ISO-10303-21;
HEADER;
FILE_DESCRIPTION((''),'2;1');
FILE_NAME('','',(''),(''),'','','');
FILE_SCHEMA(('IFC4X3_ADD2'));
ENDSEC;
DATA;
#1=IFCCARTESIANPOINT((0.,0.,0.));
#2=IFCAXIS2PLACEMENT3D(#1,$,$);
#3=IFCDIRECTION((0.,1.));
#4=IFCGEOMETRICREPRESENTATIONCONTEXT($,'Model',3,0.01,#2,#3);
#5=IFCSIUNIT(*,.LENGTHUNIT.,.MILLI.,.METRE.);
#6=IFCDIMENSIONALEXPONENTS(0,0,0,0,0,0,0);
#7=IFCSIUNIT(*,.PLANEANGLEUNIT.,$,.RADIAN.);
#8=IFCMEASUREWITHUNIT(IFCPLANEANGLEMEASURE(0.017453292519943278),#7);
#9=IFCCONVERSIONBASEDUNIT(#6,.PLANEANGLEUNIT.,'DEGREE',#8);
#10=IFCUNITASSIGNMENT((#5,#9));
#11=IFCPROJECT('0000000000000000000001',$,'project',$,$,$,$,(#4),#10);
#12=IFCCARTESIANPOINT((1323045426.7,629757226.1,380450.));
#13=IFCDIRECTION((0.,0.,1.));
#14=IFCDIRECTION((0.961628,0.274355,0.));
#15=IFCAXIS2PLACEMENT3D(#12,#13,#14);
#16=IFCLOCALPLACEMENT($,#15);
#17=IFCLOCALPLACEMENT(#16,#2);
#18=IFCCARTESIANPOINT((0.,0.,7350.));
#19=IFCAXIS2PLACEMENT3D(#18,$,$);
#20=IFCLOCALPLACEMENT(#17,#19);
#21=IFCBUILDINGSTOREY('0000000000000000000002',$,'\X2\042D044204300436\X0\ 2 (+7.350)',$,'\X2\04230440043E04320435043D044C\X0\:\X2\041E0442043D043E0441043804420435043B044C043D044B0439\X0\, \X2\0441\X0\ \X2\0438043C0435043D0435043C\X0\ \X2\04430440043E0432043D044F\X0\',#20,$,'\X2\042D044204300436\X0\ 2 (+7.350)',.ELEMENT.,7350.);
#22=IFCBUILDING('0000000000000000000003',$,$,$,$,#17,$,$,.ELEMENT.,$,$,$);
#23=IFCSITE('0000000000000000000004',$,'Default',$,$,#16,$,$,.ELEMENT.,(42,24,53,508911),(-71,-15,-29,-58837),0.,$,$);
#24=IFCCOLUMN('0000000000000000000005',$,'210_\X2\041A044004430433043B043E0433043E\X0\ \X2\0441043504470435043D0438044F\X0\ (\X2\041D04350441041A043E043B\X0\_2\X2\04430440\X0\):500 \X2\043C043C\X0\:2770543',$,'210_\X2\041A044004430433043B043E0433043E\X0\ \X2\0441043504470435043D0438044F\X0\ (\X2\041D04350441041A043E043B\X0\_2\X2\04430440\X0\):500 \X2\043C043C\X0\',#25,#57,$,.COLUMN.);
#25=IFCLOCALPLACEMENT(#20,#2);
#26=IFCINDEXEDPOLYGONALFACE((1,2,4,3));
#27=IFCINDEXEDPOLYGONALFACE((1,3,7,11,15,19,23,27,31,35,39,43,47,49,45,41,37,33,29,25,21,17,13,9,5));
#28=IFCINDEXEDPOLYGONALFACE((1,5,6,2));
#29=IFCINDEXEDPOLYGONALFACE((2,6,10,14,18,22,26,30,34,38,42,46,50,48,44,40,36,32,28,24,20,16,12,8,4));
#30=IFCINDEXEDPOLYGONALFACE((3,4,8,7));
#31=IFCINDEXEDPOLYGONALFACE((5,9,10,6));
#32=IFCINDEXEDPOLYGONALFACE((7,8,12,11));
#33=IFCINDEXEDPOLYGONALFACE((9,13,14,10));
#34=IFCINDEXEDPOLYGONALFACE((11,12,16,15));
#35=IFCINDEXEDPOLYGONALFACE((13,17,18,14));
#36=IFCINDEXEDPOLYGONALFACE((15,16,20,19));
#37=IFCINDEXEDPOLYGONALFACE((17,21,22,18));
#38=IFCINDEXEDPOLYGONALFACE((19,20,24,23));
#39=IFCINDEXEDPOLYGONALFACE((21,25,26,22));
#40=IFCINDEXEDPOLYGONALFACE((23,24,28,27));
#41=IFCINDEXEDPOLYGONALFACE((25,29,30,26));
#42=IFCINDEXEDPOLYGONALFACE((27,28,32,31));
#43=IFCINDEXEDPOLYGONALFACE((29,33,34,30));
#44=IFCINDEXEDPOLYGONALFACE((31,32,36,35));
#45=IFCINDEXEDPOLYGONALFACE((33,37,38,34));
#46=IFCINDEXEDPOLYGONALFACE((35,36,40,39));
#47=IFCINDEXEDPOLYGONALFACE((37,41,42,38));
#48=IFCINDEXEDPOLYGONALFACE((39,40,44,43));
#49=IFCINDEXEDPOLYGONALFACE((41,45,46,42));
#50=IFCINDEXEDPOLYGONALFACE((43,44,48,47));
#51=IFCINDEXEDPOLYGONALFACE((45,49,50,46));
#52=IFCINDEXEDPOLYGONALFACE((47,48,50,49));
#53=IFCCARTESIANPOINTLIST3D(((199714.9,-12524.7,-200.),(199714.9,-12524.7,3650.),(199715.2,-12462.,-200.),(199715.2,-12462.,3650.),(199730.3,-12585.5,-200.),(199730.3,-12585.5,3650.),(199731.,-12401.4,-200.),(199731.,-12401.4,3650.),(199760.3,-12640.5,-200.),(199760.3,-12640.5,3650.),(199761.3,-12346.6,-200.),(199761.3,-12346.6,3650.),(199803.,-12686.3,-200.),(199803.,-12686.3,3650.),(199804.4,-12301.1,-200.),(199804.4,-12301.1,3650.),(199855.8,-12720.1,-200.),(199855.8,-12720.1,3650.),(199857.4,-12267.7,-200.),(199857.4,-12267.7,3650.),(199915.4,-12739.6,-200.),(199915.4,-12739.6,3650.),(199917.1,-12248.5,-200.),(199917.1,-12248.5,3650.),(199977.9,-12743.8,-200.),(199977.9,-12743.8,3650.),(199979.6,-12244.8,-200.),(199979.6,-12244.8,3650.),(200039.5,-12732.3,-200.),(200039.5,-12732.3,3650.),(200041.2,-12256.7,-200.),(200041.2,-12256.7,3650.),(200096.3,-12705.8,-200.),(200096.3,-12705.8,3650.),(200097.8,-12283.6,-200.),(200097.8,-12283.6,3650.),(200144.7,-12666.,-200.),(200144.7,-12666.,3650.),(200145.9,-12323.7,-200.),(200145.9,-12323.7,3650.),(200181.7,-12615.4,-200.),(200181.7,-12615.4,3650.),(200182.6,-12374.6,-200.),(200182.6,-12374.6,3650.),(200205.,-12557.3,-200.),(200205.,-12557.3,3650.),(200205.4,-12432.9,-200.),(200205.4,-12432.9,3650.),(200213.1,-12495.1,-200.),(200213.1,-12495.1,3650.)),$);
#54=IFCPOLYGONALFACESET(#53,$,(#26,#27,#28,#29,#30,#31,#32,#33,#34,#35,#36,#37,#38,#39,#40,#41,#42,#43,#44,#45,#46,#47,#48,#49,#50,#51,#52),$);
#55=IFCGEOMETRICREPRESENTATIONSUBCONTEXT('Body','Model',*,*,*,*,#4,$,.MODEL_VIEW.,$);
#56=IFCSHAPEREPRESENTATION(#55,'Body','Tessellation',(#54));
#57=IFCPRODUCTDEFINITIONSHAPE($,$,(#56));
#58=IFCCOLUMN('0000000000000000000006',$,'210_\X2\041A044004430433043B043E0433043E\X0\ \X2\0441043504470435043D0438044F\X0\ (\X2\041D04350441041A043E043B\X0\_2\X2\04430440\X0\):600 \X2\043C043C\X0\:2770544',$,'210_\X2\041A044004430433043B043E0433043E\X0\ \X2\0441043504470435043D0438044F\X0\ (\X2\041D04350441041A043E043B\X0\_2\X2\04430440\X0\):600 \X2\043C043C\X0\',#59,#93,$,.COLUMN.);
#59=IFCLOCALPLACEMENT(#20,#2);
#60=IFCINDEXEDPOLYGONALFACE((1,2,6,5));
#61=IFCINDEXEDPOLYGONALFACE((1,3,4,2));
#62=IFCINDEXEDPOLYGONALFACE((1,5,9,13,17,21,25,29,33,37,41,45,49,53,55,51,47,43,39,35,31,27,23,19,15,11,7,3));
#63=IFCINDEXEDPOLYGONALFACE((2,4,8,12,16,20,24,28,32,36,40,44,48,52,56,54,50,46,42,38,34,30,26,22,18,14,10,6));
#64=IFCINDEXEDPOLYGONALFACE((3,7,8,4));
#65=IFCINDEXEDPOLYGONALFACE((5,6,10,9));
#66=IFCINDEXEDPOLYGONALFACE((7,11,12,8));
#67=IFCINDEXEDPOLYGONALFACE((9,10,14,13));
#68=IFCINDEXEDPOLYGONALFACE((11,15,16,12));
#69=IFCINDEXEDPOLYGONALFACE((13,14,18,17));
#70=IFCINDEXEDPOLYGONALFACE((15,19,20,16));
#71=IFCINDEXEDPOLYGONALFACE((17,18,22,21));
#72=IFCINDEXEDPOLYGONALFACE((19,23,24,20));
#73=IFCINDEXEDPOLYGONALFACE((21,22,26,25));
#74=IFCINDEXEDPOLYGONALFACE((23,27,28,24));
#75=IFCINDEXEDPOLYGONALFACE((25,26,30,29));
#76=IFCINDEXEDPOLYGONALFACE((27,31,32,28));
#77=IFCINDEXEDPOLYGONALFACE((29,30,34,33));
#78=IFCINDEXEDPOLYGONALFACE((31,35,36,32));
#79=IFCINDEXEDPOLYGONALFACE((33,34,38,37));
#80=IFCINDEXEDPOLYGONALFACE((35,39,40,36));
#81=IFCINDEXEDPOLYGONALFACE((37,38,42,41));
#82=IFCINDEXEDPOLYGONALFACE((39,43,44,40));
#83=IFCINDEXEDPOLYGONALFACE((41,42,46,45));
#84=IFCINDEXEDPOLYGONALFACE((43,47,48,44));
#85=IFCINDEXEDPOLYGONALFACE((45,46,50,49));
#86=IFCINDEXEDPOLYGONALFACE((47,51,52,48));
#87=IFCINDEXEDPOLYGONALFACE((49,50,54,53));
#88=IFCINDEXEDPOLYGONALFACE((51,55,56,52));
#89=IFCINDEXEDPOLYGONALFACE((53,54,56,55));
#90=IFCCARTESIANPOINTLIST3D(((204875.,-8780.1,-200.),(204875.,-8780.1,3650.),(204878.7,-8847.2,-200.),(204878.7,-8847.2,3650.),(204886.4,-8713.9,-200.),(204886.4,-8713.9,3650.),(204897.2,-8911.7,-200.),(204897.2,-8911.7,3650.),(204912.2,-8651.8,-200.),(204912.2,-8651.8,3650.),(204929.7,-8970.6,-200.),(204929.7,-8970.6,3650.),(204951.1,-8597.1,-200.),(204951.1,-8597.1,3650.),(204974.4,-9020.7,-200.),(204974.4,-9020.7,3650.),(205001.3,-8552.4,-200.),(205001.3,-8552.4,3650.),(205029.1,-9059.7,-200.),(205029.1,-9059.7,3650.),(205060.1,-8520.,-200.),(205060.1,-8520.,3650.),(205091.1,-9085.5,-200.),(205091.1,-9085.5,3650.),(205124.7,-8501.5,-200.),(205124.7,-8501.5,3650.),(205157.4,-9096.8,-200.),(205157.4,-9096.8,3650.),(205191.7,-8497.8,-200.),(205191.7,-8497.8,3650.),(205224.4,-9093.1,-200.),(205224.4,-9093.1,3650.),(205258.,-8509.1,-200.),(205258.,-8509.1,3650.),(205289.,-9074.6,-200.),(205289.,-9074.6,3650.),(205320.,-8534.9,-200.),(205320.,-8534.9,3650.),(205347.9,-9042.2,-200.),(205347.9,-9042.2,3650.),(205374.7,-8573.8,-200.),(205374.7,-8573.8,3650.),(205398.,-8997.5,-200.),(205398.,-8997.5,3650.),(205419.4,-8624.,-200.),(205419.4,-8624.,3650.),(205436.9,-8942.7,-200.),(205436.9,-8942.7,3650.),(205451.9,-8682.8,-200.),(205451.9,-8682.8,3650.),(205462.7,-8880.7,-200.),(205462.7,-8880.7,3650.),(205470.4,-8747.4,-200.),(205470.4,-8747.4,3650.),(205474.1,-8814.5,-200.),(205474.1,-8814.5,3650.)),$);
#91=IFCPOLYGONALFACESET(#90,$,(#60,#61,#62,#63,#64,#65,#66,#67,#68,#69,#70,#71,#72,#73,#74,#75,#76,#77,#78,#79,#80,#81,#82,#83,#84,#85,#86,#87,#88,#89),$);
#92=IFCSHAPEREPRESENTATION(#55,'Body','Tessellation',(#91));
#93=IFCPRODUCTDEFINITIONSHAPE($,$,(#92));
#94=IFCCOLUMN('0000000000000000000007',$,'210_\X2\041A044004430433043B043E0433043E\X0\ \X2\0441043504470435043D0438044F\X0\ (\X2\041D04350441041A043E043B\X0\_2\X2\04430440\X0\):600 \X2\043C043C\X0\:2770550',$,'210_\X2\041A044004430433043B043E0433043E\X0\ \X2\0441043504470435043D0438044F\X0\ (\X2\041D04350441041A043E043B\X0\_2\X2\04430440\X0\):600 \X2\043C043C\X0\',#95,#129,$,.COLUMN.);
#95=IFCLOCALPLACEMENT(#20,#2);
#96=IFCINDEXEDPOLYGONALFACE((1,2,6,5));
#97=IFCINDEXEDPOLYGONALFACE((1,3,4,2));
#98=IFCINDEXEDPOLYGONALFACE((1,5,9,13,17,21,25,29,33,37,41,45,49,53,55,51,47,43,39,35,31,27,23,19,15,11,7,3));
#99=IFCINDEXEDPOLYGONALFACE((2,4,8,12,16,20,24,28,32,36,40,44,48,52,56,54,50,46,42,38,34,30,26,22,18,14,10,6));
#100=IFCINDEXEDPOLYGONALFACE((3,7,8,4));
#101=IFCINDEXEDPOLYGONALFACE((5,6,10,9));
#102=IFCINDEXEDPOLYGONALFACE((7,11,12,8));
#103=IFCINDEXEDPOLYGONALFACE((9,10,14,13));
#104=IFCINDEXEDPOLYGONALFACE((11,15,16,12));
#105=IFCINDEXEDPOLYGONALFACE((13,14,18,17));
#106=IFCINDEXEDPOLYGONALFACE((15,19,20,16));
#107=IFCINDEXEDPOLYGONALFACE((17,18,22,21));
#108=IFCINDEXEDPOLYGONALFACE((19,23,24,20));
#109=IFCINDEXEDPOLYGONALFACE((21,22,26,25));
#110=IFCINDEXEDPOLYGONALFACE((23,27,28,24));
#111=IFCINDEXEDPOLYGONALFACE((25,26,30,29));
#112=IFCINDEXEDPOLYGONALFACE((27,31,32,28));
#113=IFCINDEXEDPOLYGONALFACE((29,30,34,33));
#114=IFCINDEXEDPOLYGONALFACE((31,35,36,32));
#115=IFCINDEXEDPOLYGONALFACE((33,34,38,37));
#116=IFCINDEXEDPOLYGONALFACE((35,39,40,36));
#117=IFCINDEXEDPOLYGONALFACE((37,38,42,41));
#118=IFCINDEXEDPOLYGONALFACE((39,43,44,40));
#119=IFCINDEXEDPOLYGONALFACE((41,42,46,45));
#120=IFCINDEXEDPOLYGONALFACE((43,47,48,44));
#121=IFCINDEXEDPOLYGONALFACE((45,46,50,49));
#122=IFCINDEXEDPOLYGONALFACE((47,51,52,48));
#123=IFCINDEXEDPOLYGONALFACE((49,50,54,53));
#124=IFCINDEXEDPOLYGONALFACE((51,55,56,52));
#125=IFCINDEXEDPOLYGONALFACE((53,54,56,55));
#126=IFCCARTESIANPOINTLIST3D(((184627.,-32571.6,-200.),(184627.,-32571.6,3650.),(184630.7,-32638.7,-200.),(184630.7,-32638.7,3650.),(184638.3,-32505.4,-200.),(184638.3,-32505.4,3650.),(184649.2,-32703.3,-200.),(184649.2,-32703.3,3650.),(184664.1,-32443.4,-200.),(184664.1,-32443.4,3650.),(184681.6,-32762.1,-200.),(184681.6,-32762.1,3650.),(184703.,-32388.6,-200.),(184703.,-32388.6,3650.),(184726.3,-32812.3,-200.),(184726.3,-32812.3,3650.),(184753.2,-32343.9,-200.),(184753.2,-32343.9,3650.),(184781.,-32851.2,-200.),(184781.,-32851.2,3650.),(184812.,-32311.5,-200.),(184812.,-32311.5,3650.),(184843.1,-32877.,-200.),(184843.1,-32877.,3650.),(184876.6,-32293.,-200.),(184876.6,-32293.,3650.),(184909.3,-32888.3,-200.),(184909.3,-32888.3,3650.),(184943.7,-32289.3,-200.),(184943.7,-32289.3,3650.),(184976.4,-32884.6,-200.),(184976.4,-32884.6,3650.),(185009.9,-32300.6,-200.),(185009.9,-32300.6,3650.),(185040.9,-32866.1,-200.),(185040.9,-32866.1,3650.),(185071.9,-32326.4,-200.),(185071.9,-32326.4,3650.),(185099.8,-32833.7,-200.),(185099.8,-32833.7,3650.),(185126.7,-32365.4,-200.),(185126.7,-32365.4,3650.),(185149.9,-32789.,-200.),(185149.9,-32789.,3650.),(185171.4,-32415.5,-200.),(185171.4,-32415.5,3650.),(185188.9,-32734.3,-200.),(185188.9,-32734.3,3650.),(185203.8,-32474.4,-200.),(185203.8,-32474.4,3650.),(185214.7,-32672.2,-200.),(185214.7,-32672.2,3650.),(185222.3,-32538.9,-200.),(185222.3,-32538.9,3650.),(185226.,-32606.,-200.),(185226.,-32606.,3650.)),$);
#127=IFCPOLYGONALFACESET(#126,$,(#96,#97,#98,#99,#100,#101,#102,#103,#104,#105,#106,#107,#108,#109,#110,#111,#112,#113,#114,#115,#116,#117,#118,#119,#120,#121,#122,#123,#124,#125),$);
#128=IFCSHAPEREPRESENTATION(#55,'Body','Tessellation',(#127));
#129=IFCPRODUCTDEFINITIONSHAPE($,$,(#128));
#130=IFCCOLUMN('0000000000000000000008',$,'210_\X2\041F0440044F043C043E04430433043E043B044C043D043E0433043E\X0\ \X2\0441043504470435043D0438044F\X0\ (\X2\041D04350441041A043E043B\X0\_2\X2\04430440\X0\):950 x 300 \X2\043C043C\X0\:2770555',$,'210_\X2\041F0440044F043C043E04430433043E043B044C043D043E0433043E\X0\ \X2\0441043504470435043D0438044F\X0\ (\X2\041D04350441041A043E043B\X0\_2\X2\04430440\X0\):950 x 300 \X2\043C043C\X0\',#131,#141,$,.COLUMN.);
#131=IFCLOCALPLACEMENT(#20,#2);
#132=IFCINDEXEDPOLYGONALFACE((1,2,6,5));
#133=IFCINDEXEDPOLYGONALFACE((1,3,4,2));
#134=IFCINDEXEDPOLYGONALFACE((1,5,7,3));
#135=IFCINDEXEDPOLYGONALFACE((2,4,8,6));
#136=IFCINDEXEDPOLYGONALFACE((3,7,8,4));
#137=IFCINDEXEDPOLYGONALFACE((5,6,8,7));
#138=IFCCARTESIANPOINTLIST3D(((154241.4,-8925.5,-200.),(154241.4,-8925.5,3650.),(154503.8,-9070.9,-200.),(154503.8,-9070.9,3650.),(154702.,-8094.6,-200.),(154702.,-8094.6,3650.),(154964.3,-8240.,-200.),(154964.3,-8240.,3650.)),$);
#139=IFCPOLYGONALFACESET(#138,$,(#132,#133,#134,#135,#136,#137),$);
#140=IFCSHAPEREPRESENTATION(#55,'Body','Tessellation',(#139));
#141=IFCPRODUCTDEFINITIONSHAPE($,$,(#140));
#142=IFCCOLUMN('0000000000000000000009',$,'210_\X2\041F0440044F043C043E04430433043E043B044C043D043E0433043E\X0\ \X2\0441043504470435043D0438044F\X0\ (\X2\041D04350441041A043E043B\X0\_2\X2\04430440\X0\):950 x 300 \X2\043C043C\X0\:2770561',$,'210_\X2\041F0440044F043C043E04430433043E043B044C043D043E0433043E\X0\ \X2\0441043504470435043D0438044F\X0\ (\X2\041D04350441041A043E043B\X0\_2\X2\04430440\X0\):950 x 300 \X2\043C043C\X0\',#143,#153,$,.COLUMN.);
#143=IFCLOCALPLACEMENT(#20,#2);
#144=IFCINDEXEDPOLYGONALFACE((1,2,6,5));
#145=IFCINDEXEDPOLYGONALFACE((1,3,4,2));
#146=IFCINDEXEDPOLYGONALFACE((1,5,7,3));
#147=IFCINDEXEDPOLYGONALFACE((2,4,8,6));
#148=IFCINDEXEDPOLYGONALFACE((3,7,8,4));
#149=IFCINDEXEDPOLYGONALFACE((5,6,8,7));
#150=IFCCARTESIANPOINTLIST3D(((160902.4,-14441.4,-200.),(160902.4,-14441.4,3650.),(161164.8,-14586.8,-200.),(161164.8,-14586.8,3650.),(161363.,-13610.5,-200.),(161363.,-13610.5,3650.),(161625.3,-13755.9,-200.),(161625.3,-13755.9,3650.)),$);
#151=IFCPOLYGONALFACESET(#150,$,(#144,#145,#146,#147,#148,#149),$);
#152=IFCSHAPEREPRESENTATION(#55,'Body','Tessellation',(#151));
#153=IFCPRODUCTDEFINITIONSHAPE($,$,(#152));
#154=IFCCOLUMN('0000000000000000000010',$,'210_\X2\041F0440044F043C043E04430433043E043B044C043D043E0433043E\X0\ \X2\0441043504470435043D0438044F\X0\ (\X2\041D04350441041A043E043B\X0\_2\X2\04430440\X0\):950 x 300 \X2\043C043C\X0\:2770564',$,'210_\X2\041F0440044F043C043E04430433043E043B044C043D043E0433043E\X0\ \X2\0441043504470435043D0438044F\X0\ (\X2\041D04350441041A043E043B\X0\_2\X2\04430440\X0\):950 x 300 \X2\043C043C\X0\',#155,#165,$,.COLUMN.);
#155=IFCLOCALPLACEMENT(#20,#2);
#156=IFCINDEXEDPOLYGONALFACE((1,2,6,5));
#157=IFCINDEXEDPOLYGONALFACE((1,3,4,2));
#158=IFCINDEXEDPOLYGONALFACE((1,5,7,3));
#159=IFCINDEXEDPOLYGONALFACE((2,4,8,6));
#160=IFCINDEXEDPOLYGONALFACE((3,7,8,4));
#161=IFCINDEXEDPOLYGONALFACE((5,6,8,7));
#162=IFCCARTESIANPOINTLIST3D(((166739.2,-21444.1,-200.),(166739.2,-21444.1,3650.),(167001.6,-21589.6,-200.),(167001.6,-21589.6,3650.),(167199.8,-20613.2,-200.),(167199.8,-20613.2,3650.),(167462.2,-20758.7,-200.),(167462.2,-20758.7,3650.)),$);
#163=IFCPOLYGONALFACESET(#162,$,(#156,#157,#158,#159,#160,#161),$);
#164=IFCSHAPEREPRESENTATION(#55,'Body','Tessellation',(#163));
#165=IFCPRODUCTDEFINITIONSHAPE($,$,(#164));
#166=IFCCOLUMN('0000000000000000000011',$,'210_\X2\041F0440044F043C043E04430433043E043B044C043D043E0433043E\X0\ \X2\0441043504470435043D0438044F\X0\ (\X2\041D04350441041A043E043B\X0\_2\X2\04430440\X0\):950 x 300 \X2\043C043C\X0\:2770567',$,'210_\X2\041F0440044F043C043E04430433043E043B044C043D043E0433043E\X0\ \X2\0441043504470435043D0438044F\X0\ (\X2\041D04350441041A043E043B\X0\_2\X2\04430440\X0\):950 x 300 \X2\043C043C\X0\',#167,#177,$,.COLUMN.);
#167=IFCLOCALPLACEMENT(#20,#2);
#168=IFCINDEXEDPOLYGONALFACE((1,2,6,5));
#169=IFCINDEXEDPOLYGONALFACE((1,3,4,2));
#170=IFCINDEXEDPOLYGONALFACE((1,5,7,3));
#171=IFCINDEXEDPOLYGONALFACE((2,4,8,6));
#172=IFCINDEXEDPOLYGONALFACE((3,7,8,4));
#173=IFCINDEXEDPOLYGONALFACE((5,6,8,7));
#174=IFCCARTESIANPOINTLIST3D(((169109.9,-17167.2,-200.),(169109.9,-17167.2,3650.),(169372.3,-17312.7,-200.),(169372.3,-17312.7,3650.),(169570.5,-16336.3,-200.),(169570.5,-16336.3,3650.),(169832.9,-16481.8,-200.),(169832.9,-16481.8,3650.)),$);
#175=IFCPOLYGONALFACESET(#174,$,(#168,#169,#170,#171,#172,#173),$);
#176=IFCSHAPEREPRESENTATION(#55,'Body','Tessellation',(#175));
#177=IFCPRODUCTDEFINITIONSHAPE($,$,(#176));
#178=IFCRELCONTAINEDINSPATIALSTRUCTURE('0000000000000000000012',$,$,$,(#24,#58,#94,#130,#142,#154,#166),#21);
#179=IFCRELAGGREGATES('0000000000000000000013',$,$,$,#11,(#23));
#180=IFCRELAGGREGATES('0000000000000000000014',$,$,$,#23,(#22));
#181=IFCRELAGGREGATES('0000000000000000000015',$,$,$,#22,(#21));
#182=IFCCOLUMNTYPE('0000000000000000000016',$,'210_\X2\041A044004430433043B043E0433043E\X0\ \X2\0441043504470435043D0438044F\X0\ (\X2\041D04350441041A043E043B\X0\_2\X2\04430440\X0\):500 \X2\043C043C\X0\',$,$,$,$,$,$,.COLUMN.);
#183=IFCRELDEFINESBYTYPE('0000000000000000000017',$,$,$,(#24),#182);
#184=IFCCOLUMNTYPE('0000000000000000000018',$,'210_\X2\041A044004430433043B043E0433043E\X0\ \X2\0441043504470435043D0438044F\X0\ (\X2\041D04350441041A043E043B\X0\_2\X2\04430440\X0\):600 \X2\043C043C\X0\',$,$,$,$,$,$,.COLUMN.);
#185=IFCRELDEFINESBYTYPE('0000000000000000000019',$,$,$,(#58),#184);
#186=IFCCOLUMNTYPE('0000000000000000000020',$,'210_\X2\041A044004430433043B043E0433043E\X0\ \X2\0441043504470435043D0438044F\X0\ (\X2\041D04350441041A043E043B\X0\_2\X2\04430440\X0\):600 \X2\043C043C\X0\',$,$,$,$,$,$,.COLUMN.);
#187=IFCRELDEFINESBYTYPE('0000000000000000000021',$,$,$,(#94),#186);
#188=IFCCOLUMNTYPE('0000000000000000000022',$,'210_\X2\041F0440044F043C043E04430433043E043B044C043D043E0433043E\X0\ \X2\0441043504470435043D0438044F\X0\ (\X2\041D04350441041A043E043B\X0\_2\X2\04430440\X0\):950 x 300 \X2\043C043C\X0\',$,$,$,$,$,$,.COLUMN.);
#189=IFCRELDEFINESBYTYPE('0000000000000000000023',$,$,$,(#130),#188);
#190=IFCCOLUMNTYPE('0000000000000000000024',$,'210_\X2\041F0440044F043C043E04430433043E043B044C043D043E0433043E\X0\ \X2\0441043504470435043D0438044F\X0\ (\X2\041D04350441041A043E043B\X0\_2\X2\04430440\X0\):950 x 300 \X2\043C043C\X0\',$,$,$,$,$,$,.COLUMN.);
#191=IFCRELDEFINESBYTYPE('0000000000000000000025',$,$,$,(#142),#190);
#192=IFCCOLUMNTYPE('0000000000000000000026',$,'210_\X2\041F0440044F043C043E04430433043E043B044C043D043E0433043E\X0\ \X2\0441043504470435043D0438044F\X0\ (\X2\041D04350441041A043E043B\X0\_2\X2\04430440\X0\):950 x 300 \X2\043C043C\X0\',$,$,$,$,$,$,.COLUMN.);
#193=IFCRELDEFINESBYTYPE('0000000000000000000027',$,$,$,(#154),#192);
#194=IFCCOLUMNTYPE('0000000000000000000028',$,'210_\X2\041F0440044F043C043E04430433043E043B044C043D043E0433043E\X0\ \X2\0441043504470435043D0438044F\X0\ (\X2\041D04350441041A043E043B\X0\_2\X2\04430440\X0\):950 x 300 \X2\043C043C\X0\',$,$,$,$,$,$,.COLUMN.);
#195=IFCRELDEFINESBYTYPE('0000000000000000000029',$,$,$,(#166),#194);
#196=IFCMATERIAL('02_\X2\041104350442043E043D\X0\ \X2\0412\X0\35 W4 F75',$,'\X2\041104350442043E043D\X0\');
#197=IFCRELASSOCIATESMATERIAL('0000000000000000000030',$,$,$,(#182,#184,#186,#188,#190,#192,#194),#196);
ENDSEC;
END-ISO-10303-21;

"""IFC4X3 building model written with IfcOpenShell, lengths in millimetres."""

from ifc_helpers import new_model, entity, si_unit, converted_unit, direction, frame, frame_2d, origin, origin_2d_with_axis, place, context, subcontext, project, spatial, rectangle, circle, extrude, source, transform, mapped, material, material_profile, profile_set, type_object, type_shapes, element, save


model = new_model("IFC4X3")

# Units and contexts
model_context = context("Model", 3, precision=0.01, world=origin(), true_north=direction((0.0, 1.0)))
body_context = subcontext(model_context, "Body", "Model", "MODEL_VIEW")
ifc_project = project(units=[si_unit("LENGTHUNIT", "METRE", prefix="MILLI"), converted_unit("PLANEANGLEUNIT", "DEGREE", entity("IfcPlaneAngleMeasure", 0.017453292519943278), si_unit("PLANEANGLEUNIT", "RADIAN"), dimensions=[0, 0, 0, 0, 0, 0, 0])], contexts=[model_context])

# Site, building, storey
site_placement = place(None, frame((1323045426.7, 629757226.1, 380450.0), z_axis=(0.0, 0.0, 1.0), x_axis=(0.961628, 0.274355, 0.0)))
site = spatial("IfcSite", under=ifc_project, at=site_placement, Name="Default", CompositionType="ELEMENT", RefLatitude=(42, 24, 53, 508911), RefLongitude=(-71, -15, -29, -58837), RefElevation=0.0)
building_placement = place(site_placement, origin())
building = spatial("IfcBuilding", under=site, at=building_placement, CompositionType="ELEMENT")
storey_placement = place(building_placement, frame((0.0, 0.0, 7350.0)))
storey = spatial("IfcBuildingStorey", under=building, at=storey_placement, Name="Этаж 2 (+7.350)", ObjectType="Уровень:Относительный, с именем уровня", LongName="Этаж 2 (+7.350)", CompositionType="ELEMENT", Elevation=7350.0)

# Columns
ifc_material = material(Name="02_Бетон В35 W4 F75", Category="Бетон")
ifc_material_profile_1 = material_profile(ifc_material, circle(Radius=250.0, at=frame_2d((0.0, 0.0), x_axis=(1.0, 0.0))), Name="500 мм")
ifc_profile_set_1 = profile_set([ifc_material_profile_1], Name="500 мм")
ifc_material_profile_2 = material_profile(ifc_material, circle(Radius=300.0, at=origin_2d_with_axis()), Name="600 мм")
ifc_profile_set_2 = profile_set([ifc_material_profile_2], Name="600 мм")
column_type_1 = type_object("IfcColumnType", Name="210_Круглого сечения (НесКол_2ур):500 мм", PredefinedType="COLUMN", material=ifc_profile_set_1)
shared_shape_1 = source(origin(), body_context, "Body", "SweptSolid", [
    extrude(circle(Radius=250.0, at=origin_2d_with_axis()), frame((199963.1, -12494.2, 7150.0), z_axis=(0.0, 0.0, 1.0), x_axis=(0.87462, -0.48481, 0.0)), (0.0, 0.0, 1.0), 3850.0),
])
type_shapes(column_type_1, [shared_shape_1])
column_1_placement = place(storey_placement, frame((0.0, 0.0, -7350.0)))
element("IfcColumn", 1, at=column_1_placement, inside=storey, type_object=column_type_1, Name="210_Круглого сечения (НесКол_2ур):500 мм:2770543", ObjectType="210_Круглого сечения (НесКол_2ур):500 мм", PredefinedType="COLUMN", context=body_context, shape_type="MappedRepresentation", body=[
    mapped(shared_shape_1, transform((0.0, 0.0, 0.0), scale=1.0)),
])
column_type_2 = type_object("IfcColumnType", Name="210_Круглого сечения (НесКол_2ур):600 мм", PredefinedType="COLUMN", material=ifc_profile_set_2)
shared_shape_2 = source(origin(), body_context, "Body", "SweptSolid", [
    extrude(circle(Radius=300.0, at=origin_2d_with_axis()), frame((205174.6, -8797.3, 7150.0), z_axis=(0.0, 0.0, 1.0), x_axis=(0.87462, -0.48481, 0.0)), (0.0, 0.0, 1.0), 3850.0),
])
type_shapes(column_type_2, [shared_shape_2])
column_2_placement = place(storey_placement, frame((0.0, 0.0, -7350.0)))
element("IfcColumn", 2, at=column_2_placement, inside=storey, type_object=column_type_2, Name="210_Круглого сечения (НесКол_2ур):600 мм:2770544", ObjectType="210_Круглого сечения (НесКол_2ур):600 мм", PredefinedType="COLUMN", context=body_context, shape_type="MappedRepresentation", body=[
    mapped(shared_shape_2, transform((0.0, 0.0, 0.0), scale=1.0)),
])
column_type_3 = type_object("IfcColumnType", Name="210_Круглого сечения (НесКол_2ур):600 мм", PredefinedType="COLUMN", material=ifc_profile_set_2)
shared_shape_3 = source(origin(), body_context, "Body", "SweptSolid", [
    extrude(circle(Radius=300.0, at=origin_2d_with_axis()), frame((184926.5, -32588.8, 7150.0), z_axis=(0.0, 0.0, 1.0), x_axis=(0.87462, -0.48481, 0.0)), (0.0, 0.0, 1.0), 3850.0),
])
type_shapes(column_type_3, [shared_shape_3])
column_3_placement = place(storey_placement, frame((0.0, 0.0, -7350.0)))
element("IfcColumn", 3, at=column_3_placement, inside=storey, type_object=column_type_3, Name="210_Круглого сечения (НесКол_2ур):600 мм:2770550", ObjectType="210_Круглого сечения (НесКол_2ур):600 мм", PredefinedType="COLUMN", context=body_context, shape_type="MappedRepresentation", body=[
    mapped(shared_shape_3, transform((0.0, 0.0, 0.0), scale=1.0)),
])
ifc_material_profile_3 = material_profile(ifc_material, rectangle(XDim=300.0, YDim=950.0, at=origin_2d_with_axis()), Name="950 x 300 мм")
ifc_profile_set_3 = profile_set([ifc_material_profile_3], Name="950 x 300 мм")
column_type_4 = type_object("IfcColumnType", Name="210_Прямоугольного сечения (НесКол_2ур):950 x 300 мм", PredefinedType="COLUMN", material=ifc_profile_set_3)
shared_shape_4 = source(origin(), body_context, "Body", "SweptSolid", [
    extrude(rectangle(XDim=300.0, YDim=950.0, at=origin_2d_with_axis()), frame((154602.9, -8582.8, 7150.0), z_axis=(0.0, 0.0, 1.0), x_axis=(-0.87462, 0.48481, 0.0)), (0.0, 0.0, 1.0), 3850.0),
])
type_shapes(column_type_4, [shared_shape_4])
column_4_placement = place(storey_placement, frame((0.0, 0.0, -7350.0)))
element("IfcColumn", 4, at=column_4_placement, inside=storey, type_object=column_type_4, Name="210_Прямоугольного сечения (НесКол_2ур):950 x 300 мм:2770555", ObjectType="210_Прямоугольного сечения (НесКол_2ур):950 x 300 мм", PredefinedType="COLUMN", context=body_context, shape_type="MappedRepresentation", body=[
    mapped(shared_shape_4, transform((0.0, 0.0, 0.0), scale=1.0)),
])
column_type_5 = type_object("IfcColumnType", Name="210_Прямоугольного сечения (НесКол_2ур):950 x 300 мм", PredefinedType="COLUMN", material=ifc_profile_set_3)
shared_shape_5 = source(origin(), body_context, "Body", "SweptSolid", [
    extrude(rectangle(XDim=300.0, YDim=950.0, at=origin_2d_with_axis()), frame((161263.9, -14098.7, 7150.0), z_axis=(0.0, 0.0, 1.0), x_axis=(-0.87462, 0.48481, 0.0)), (0.0, 0.0, 1.0), 3850.0),
])
type_shapes(column_type_5, [shared_shape_5])
column_5_placement = place(storey_placement, frame((0.0, 0.0, -7350.0)))
element("IfcColumn", 5, at=column_5_placement, inside=storey, type_object=column_type_5, Name="210_Прямоугольного сечения (НесКол_2ур):950 x 300 мм:2770561", ObjectType="210_Прямоугольного сечения (НесКол_2ур):950 x 300 мм", PredefinedType="COLUMN", context=body_context, shape_type="MappedRepresentation", body=[
    mapped(shared_shape_5, transform((0.0, 0.0, 0.0), scale=1.0)),
])
column_type_6 = type_object("IfcColumnType", Name="210_Прямоугольного сечения (НесКол_2ур):950 x 300 мм", PredefinedType="COLUMN", material=ifc_profile_set_3)
shared_shape_6 = source(origin(), body_context, "Body", "SweptSolid", [
    extrude(rectangle(XDim=300.0, YDim=950.0, at=frame_2d((0.0, 0.0), x_axis=(1.0, 0.0))), frame((167100.7, -21101.4, 7150.0), z_axis=(0.0, 0.0, 1.0), x_axis=(-0.87462, 0.48481, 0.0)), (0.0, 0.0, 1.0), 3850.0),
])
type_shapes(column_type_6, [shared_shape_6])
column_6_placement = place(storey_placement, frame((0.0, 0.0, -7350.0)))
element("IfcColumn", 6, at=column_6_placement, inside=storey, type_object=column_type_6, Name="210_Прямоугольного сечения (НесКол_2ур):950 x 300 мм:2770564", ObjectType="210_Прямоугольного сечения (НесКол_2ур):950 x 300 мм", PredefinedType="COLUMN", context=body_context, shape_type="MappedRepresentation", body=[
    mapped(shared_shape_6, transform((0.0, 0.0, 0.0), scale=1.0)),
])
column_type_7 = type_object("IfcColumnType", Name="210_Прямоугольного сечения (НесКол_2ур):950 x 300 мм", PredefinedType="COLUMN", material=ifc_profile_set_3)
shared_shape_7 = source(origin(), body_context, "Body", "SweptSolid", [
    extrude(rectangle(XDim=300.0, YDim=950.0, at=origin_2d_with_axis()), frame((169471.4, -16824.5, 7150.0), z_axis=(0.0, 0.0, 1.0), x_axis=(-0.87462, 0.48481, 0.0)), (0.0, 0.0, 1.0), 3850.0),
])
type_shapes(column_type_7, [shared_shape_7])
column_7_placement = place(storey_placement, frame((0.0, 0.0, -7350.0)))
element("IfcColumn", 7, at=column_7_placement, inside=storey, type_object=column_type_7, Name="210_Прямоугольного сечения (НесКол_2ур):950 x 300 мм:2770567", ObjectType="210_Прямоугольного сечения (НесКол_2ур):950 x 300 мм", PredefinedType="COLUMN", context=body_context, shape_type="MappedRepresentation", body=[
    mapped(shared_shape_7, transform((0.0, 0.0, 0.0), scale=1.0)),
])

save(model, "model.ifc")
